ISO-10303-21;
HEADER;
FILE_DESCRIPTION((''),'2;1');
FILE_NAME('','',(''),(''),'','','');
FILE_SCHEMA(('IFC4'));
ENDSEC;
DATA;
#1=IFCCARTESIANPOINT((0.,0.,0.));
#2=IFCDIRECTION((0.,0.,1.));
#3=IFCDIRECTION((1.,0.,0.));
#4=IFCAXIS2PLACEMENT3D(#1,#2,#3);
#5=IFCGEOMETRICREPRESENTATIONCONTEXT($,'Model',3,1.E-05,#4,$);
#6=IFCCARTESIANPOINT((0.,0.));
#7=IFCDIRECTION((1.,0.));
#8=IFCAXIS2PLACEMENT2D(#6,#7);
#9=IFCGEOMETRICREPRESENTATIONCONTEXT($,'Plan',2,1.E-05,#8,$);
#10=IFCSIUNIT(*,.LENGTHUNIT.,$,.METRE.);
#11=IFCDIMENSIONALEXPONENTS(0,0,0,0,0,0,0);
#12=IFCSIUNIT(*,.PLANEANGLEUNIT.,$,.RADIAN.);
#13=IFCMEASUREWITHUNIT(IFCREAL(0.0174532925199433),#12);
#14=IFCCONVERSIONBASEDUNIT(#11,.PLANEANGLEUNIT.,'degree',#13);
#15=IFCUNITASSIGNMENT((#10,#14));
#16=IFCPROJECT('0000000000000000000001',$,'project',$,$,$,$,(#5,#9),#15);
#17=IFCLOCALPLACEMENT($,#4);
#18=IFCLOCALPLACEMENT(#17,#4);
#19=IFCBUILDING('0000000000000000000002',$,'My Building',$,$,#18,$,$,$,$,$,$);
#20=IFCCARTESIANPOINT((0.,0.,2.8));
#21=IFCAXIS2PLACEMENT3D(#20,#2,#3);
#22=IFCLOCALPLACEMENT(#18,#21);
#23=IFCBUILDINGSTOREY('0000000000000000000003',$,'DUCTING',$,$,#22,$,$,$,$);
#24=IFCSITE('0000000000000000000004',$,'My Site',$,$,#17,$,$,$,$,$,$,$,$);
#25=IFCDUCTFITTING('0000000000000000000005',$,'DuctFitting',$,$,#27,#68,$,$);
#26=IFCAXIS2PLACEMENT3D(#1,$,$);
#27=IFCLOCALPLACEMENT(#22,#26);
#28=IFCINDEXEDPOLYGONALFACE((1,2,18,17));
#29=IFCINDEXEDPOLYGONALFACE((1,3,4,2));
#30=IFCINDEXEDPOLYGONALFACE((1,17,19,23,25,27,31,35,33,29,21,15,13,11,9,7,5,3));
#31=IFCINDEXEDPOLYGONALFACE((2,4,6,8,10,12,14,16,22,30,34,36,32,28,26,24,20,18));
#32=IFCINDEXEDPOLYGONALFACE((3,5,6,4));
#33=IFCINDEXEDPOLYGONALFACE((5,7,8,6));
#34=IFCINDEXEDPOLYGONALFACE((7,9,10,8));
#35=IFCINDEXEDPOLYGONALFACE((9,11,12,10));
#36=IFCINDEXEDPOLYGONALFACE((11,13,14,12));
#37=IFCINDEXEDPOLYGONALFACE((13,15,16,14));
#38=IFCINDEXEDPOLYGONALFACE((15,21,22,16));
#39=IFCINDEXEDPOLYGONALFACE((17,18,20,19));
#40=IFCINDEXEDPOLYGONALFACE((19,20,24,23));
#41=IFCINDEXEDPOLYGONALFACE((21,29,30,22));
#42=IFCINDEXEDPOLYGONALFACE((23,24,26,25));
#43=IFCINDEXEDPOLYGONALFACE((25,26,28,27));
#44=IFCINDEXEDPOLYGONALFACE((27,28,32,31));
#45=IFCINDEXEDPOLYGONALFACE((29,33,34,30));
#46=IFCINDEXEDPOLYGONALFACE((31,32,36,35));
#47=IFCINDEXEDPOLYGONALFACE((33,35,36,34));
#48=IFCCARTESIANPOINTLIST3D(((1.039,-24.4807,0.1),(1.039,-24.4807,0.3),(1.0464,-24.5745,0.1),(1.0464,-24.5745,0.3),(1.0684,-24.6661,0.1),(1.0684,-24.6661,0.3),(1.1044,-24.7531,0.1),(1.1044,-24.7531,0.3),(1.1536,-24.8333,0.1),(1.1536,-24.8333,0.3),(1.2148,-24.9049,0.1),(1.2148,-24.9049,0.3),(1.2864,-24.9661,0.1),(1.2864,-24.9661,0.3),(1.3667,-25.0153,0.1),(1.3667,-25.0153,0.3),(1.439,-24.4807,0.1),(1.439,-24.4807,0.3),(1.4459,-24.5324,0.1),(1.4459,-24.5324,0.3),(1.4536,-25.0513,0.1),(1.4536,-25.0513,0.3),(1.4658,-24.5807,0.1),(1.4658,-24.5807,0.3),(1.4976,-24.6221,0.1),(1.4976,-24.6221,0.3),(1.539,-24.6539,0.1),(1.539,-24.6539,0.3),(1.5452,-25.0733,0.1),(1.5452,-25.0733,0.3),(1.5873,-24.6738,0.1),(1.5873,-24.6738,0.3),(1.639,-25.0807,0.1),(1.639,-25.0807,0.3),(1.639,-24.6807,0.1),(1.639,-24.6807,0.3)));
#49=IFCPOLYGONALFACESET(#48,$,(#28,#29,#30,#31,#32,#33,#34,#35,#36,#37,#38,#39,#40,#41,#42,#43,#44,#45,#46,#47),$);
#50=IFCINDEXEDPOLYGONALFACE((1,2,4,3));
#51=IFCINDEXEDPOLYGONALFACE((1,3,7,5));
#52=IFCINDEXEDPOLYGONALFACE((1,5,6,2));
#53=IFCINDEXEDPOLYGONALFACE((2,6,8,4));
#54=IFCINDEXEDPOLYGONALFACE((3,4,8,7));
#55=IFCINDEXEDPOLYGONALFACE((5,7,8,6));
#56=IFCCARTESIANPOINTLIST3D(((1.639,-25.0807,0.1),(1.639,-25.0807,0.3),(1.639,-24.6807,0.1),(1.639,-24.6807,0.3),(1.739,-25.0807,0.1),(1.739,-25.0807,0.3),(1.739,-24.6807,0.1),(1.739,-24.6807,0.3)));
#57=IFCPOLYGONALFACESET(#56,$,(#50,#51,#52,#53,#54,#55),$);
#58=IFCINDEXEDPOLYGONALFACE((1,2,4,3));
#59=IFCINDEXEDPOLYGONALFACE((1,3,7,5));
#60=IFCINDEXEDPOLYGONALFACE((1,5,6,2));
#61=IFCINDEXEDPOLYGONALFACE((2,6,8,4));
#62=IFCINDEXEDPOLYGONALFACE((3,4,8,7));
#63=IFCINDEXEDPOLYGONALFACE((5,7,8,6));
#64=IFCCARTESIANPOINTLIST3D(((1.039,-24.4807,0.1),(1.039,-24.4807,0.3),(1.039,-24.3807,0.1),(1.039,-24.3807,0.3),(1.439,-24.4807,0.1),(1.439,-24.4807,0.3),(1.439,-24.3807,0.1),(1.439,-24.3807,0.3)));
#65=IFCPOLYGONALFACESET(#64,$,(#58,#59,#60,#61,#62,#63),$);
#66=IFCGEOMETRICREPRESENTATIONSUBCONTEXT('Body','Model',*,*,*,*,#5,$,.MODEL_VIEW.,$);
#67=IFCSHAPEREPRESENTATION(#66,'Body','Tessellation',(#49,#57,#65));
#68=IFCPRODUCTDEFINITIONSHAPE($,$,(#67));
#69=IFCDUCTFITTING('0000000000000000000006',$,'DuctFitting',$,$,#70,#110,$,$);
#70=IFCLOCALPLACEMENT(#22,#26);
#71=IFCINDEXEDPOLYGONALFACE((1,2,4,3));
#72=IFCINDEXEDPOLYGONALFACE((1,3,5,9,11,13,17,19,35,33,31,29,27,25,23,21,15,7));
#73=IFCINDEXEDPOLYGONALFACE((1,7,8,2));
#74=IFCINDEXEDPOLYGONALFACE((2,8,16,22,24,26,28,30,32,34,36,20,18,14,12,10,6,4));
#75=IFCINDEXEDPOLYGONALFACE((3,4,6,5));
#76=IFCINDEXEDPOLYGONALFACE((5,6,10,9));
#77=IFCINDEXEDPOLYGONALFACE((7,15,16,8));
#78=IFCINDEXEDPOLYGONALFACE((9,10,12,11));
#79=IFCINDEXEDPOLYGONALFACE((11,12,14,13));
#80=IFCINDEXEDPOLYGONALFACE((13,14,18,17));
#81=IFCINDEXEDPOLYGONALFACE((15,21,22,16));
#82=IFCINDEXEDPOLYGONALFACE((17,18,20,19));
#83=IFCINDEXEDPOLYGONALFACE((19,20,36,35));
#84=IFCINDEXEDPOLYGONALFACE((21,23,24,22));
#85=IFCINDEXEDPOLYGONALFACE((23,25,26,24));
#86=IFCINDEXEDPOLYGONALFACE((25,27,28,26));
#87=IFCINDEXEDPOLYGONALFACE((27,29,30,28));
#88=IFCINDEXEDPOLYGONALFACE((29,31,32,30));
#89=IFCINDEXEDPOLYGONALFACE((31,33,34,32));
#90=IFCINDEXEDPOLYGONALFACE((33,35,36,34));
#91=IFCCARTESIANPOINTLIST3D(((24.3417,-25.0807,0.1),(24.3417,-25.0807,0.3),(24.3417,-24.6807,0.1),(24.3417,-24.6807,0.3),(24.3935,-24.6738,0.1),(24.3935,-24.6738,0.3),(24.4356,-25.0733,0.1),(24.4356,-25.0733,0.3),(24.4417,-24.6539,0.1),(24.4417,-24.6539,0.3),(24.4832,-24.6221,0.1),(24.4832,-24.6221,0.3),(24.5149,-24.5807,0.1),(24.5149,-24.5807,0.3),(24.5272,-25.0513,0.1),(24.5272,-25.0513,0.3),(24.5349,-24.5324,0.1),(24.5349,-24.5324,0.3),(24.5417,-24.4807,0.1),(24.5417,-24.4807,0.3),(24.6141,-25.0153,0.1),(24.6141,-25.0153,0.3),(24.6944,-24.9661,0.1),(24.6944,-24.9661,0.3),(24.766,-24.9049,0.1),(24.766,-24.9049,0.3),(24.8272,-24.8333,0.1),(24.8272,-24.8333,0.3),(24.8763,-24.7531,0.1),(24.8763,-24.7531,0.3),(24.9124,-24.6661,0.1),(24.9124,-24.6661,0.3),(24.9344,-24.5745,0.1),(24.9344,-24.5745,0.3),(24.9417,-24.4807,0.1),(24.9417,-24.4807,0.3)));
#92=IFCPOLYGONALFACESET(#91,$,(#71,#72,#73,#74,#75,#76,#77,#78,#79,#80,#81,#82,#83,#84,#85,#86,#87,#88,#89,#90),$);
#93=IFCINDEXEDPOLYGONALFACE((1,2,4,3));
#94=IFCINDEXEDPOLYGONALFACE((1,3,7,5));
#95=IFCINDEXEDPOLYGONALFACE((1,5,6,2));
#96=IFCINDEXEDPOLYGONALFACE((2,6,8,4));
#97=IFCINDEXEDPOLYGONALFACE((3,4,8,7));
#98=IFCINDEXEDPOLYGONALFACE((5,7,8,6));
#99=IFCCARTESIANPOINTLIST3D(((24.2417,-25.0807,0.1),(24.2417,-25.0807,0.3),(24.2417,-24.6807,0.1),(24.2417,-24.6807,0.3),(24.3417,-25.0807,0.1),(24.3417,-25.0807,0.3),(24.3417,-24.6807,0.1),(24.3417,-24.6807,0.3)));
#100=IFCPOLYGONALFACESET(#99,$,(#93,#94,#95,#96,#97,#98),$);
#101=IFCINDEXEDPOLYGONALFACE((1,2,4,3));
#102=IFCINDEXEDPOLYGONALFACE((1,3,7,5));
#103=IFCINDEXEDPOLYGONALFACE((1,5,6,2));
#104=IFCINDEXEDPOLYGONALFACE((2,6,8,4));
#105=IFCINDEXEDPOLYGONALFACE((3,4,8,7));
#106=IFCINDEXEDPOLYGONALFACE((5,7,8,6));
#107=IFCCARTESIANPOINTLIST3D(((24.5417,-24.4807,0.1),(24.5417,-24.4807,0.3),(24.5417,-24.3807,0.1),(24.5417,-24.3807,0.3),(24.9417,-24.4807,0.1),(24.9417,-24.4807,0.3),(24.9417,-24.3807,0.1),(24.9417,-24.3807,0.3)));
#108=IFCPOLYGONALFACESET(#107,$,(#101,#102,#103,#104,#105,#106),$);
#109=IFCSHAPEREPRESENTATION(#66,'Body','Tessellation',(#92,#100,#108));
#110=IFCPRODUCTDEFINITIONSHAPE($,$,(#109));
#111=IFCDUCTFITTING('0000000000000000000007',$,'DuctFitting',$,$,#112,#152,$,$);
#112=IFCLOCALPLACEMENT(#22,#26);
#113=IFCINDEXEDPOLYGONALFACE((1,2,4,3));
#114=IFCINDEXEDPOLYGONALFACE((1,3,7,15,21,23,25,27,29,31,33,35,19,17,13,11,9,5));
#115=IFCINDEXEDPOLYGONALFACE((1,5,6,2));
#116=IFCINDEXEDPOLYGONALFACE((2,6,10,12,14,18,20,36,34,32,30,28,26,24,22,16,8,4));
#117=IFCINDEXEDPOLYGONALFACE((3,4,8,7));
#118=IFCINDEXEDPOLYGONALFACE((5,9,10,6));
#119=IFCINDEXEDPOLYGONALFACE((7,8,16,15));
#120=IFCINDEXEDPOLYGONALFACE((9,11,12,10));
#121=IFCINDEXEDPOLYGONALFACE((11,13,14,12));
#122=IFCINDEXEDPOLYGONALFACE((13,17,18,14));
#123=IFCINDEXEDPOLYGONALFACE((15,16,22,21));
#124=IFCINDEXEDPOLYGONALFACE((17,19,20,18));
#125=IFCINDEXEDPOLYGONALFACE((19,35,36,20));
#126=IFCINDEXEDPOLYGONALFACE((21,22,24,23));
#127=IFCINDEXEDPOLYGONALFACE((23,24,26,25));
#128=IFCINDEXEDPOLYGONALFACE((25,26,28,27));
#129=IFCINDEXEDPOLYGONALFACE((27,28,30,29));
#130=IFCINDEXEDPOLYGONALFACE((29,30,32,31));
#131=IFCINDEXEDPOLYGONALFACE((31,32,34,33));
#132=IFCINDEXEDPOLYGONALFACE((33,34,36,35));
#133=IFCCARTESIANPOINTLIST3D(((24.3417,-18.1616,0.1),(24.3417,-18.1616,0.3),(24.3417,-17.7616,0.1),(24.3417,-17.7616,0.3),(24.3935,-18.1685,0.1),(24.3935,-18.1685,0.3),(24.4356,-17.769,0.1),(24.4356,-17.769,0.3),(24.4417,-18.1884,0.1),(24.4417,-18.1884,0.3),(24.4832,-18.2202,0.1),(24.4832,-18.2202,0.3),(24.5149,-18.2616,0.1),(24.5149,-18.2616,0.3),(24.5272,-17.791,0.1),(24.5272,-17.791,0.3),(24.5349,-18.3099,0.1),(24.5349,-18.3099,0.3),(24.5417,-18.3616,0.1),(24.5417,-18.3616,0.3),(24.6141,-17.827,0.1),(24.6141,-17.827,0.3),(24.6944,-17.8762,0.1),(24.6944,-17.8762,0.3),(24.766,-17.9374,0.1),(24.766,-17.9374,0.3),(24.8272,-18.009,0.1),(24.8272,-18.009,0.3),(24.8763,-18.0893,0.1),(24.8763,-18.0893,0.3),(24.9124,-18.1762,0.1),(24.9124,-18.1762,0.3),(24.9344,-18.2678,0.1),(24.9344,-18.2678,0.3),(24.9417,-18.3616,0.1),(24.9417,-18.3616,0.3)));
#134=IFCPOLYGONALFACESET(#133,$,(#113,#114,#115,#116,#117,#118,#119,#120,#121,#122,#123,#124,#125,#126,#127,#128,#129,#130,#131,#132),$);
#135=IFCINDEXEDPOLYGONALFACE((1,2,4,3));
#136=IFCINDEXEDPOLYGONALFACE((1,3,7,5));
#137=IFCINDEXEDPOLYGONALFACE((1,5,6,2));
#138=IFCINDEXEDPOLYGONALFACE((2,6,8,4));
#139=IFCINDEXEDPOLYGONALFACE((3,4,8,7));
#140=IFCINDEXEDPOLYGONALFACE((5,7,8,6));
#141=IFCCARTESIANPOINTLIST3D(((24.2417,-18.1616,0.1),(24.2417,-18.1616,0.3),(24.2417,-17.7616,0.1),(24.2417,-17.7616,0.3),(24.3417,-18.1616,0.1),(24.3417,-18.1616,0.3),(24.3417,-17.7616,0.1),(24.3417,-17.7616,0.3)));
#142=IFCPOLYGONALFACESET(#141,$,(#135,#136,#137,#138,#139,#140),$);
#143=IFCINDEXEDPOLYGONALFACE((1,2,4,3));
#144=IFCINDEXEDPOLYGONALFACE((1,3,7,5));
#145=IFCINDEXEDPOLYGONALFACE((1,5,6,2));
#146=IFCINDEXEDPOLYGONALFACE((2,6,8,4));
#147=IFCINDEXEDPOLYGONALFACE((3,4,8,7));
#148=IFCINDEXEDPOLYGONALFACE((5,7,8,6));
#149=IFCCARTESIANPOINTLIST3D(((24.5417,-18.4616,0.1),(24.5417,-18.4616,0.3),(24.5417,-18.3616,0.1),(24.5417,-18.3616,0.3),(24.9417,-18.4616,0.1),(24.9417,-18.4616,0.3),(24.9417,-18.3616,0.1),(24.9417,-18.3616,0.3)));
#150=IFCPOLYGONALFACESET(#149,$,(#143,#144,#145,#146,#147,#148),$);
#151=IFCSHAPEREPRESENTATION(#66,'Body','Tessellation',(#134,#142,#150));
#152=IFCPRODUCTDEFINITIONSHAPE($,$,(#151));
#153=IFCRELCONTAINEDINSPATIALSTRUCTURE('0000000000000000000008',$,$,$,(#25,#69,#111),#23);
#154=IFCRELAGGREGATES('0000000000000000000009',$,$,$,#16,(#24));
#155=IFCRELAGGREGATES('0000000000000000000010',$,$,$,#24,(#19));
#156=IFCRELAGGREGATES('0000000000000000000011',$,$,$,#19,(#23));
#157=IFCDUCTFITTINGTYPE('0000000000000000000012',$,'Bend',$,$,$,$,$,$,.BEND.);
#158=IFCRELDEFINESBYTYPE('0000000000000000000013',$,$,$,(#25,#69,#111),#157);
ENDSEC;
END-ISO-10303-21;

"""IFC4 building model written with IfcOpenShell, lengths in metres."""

from ifc_helpers import new_model, entity, si_unit, converted_unit, frame, origin_with_axes, origin_2d_with_axis, place, context, subcontext, project, spatial, line, arc, indexed_curve, rectangle, outline, extrude, source, transform, mapped, type_object, type_shapes, element, save


model = new_model("IFC4")

# Units and contexts
model_context = context("Model", 3, precision=1e-05, world=origin_with_axes())
plan_context = context("Plan", 2, precision=1e-05, world=origin_2d_with_axis())
body_context = subcontext(model_context, "Body", "Model", "MODEL_VIEW")
ifc_project = project(units=[si_unit("LENGTHUNIT", "METRE"), converted_unit("PLANEANGLEUNIT", "degree", entity("IfcReal", 0.0174532925199433), si_unit("PLANEANGLEUNIT", "RADIAN"), dimensions=[0, 0, 0, 0, 0, 0, 0])], contexts=[model_context, plan_context])

# Site, building, storey
site_placement = place(None, origin_with_axes())
site = spatial("IfcSite", under=ifc_project, at=site_placement, Name="My Site")
building_placement = place(site_placement, origin_with_axes())
building = spatial("IfcBuilding", under=site, at=building_placement, Name="My Building")
storey_placement = place(building_placement, frame((0.0, 0.0, 2.8), z_axis=(0.0, 0.0, 1.0), x_axis=(1.0, 0.0, 0.0)))
storey = spatial("IfcBuildingStorey", under=building, at=storey_placement, Name="DUCTING")

# Duct fittings
duct_fitting_type = type_object("IfcDuctFittingType", Name="Bend", PredefinedType="BEND")
shared_shape = source(origin_with_axes(), body_context, "Body", "SweptSolid", [
    extrude(outline(indexed_curve([(0.2, 0.0), (0.2586, -0.1414), (0.4, -0.2), (0.4, -0.6), (-0.0243, -0.4243), (-0.2, 0.0)], segments=[arc(1, 2, 3), line(3, 4), arc(4, 5, 6), line(6, 1)])), frame((0.0, -0.1, -0.1), z_axis=(0.0, -1.0, 0.0), x_axis=(1.0, 0.0, 0.0)), (0.0, 0.0, -1.0), 0.2),
    extrude(rectangle(XDim=0.4, YDim=0.2), origin_with_axes(), (0.0, 0.0, -1.0), 0.1),
    extrude(rectangle(XDim=0.4, YDim=0.2), frame((0.4, 0.0, -0.5), z_axis=(1.0, 0.0, 0.0), x_axis=(0.0, 0.0, 1.0)), (0.0, 0.0, 1.0), 0.1),
])
type_shapes(duct_fitting_type, [shared_shape])
for number, where, z_axis, x_axis, name in (
    (1, (1.739, -24.8807, 0.2), (1.0, 0.0, 0.0), (0.0, 1.0, 0.0), "DuctFitting"),
    (2, (24.2417, -24.8807, 0.2), (-1.0, 0.0, 0.0), (0.0, 1.0, 0.0), "DuctFitting"),
    (3, (24.2417, -17.9616, 0.2), (-1.0, 0.0, 0.0), (0.0, -1.0, 0.0), "DuctFitting"),
):
    element("IfcDuctFitting", number, at=place(storey_placement, frame(where, z_axis=z_axis, x_axis=x_axis)), inside=storey, type_object=duct_fitting_type, Name=name, context=body_context, shape_type="MappedRepresentation", body=[
        mapped(shared_shape, transform((0.0, 0.0, 0.0), x_axis=(1.0, 0.0, 0.0), y_axis=(0.0, 1.0, 0.0), z_axis=(0.0, 0.0, 1.0), scale=1.0)),
    ])

save(model, "model.ifc")
